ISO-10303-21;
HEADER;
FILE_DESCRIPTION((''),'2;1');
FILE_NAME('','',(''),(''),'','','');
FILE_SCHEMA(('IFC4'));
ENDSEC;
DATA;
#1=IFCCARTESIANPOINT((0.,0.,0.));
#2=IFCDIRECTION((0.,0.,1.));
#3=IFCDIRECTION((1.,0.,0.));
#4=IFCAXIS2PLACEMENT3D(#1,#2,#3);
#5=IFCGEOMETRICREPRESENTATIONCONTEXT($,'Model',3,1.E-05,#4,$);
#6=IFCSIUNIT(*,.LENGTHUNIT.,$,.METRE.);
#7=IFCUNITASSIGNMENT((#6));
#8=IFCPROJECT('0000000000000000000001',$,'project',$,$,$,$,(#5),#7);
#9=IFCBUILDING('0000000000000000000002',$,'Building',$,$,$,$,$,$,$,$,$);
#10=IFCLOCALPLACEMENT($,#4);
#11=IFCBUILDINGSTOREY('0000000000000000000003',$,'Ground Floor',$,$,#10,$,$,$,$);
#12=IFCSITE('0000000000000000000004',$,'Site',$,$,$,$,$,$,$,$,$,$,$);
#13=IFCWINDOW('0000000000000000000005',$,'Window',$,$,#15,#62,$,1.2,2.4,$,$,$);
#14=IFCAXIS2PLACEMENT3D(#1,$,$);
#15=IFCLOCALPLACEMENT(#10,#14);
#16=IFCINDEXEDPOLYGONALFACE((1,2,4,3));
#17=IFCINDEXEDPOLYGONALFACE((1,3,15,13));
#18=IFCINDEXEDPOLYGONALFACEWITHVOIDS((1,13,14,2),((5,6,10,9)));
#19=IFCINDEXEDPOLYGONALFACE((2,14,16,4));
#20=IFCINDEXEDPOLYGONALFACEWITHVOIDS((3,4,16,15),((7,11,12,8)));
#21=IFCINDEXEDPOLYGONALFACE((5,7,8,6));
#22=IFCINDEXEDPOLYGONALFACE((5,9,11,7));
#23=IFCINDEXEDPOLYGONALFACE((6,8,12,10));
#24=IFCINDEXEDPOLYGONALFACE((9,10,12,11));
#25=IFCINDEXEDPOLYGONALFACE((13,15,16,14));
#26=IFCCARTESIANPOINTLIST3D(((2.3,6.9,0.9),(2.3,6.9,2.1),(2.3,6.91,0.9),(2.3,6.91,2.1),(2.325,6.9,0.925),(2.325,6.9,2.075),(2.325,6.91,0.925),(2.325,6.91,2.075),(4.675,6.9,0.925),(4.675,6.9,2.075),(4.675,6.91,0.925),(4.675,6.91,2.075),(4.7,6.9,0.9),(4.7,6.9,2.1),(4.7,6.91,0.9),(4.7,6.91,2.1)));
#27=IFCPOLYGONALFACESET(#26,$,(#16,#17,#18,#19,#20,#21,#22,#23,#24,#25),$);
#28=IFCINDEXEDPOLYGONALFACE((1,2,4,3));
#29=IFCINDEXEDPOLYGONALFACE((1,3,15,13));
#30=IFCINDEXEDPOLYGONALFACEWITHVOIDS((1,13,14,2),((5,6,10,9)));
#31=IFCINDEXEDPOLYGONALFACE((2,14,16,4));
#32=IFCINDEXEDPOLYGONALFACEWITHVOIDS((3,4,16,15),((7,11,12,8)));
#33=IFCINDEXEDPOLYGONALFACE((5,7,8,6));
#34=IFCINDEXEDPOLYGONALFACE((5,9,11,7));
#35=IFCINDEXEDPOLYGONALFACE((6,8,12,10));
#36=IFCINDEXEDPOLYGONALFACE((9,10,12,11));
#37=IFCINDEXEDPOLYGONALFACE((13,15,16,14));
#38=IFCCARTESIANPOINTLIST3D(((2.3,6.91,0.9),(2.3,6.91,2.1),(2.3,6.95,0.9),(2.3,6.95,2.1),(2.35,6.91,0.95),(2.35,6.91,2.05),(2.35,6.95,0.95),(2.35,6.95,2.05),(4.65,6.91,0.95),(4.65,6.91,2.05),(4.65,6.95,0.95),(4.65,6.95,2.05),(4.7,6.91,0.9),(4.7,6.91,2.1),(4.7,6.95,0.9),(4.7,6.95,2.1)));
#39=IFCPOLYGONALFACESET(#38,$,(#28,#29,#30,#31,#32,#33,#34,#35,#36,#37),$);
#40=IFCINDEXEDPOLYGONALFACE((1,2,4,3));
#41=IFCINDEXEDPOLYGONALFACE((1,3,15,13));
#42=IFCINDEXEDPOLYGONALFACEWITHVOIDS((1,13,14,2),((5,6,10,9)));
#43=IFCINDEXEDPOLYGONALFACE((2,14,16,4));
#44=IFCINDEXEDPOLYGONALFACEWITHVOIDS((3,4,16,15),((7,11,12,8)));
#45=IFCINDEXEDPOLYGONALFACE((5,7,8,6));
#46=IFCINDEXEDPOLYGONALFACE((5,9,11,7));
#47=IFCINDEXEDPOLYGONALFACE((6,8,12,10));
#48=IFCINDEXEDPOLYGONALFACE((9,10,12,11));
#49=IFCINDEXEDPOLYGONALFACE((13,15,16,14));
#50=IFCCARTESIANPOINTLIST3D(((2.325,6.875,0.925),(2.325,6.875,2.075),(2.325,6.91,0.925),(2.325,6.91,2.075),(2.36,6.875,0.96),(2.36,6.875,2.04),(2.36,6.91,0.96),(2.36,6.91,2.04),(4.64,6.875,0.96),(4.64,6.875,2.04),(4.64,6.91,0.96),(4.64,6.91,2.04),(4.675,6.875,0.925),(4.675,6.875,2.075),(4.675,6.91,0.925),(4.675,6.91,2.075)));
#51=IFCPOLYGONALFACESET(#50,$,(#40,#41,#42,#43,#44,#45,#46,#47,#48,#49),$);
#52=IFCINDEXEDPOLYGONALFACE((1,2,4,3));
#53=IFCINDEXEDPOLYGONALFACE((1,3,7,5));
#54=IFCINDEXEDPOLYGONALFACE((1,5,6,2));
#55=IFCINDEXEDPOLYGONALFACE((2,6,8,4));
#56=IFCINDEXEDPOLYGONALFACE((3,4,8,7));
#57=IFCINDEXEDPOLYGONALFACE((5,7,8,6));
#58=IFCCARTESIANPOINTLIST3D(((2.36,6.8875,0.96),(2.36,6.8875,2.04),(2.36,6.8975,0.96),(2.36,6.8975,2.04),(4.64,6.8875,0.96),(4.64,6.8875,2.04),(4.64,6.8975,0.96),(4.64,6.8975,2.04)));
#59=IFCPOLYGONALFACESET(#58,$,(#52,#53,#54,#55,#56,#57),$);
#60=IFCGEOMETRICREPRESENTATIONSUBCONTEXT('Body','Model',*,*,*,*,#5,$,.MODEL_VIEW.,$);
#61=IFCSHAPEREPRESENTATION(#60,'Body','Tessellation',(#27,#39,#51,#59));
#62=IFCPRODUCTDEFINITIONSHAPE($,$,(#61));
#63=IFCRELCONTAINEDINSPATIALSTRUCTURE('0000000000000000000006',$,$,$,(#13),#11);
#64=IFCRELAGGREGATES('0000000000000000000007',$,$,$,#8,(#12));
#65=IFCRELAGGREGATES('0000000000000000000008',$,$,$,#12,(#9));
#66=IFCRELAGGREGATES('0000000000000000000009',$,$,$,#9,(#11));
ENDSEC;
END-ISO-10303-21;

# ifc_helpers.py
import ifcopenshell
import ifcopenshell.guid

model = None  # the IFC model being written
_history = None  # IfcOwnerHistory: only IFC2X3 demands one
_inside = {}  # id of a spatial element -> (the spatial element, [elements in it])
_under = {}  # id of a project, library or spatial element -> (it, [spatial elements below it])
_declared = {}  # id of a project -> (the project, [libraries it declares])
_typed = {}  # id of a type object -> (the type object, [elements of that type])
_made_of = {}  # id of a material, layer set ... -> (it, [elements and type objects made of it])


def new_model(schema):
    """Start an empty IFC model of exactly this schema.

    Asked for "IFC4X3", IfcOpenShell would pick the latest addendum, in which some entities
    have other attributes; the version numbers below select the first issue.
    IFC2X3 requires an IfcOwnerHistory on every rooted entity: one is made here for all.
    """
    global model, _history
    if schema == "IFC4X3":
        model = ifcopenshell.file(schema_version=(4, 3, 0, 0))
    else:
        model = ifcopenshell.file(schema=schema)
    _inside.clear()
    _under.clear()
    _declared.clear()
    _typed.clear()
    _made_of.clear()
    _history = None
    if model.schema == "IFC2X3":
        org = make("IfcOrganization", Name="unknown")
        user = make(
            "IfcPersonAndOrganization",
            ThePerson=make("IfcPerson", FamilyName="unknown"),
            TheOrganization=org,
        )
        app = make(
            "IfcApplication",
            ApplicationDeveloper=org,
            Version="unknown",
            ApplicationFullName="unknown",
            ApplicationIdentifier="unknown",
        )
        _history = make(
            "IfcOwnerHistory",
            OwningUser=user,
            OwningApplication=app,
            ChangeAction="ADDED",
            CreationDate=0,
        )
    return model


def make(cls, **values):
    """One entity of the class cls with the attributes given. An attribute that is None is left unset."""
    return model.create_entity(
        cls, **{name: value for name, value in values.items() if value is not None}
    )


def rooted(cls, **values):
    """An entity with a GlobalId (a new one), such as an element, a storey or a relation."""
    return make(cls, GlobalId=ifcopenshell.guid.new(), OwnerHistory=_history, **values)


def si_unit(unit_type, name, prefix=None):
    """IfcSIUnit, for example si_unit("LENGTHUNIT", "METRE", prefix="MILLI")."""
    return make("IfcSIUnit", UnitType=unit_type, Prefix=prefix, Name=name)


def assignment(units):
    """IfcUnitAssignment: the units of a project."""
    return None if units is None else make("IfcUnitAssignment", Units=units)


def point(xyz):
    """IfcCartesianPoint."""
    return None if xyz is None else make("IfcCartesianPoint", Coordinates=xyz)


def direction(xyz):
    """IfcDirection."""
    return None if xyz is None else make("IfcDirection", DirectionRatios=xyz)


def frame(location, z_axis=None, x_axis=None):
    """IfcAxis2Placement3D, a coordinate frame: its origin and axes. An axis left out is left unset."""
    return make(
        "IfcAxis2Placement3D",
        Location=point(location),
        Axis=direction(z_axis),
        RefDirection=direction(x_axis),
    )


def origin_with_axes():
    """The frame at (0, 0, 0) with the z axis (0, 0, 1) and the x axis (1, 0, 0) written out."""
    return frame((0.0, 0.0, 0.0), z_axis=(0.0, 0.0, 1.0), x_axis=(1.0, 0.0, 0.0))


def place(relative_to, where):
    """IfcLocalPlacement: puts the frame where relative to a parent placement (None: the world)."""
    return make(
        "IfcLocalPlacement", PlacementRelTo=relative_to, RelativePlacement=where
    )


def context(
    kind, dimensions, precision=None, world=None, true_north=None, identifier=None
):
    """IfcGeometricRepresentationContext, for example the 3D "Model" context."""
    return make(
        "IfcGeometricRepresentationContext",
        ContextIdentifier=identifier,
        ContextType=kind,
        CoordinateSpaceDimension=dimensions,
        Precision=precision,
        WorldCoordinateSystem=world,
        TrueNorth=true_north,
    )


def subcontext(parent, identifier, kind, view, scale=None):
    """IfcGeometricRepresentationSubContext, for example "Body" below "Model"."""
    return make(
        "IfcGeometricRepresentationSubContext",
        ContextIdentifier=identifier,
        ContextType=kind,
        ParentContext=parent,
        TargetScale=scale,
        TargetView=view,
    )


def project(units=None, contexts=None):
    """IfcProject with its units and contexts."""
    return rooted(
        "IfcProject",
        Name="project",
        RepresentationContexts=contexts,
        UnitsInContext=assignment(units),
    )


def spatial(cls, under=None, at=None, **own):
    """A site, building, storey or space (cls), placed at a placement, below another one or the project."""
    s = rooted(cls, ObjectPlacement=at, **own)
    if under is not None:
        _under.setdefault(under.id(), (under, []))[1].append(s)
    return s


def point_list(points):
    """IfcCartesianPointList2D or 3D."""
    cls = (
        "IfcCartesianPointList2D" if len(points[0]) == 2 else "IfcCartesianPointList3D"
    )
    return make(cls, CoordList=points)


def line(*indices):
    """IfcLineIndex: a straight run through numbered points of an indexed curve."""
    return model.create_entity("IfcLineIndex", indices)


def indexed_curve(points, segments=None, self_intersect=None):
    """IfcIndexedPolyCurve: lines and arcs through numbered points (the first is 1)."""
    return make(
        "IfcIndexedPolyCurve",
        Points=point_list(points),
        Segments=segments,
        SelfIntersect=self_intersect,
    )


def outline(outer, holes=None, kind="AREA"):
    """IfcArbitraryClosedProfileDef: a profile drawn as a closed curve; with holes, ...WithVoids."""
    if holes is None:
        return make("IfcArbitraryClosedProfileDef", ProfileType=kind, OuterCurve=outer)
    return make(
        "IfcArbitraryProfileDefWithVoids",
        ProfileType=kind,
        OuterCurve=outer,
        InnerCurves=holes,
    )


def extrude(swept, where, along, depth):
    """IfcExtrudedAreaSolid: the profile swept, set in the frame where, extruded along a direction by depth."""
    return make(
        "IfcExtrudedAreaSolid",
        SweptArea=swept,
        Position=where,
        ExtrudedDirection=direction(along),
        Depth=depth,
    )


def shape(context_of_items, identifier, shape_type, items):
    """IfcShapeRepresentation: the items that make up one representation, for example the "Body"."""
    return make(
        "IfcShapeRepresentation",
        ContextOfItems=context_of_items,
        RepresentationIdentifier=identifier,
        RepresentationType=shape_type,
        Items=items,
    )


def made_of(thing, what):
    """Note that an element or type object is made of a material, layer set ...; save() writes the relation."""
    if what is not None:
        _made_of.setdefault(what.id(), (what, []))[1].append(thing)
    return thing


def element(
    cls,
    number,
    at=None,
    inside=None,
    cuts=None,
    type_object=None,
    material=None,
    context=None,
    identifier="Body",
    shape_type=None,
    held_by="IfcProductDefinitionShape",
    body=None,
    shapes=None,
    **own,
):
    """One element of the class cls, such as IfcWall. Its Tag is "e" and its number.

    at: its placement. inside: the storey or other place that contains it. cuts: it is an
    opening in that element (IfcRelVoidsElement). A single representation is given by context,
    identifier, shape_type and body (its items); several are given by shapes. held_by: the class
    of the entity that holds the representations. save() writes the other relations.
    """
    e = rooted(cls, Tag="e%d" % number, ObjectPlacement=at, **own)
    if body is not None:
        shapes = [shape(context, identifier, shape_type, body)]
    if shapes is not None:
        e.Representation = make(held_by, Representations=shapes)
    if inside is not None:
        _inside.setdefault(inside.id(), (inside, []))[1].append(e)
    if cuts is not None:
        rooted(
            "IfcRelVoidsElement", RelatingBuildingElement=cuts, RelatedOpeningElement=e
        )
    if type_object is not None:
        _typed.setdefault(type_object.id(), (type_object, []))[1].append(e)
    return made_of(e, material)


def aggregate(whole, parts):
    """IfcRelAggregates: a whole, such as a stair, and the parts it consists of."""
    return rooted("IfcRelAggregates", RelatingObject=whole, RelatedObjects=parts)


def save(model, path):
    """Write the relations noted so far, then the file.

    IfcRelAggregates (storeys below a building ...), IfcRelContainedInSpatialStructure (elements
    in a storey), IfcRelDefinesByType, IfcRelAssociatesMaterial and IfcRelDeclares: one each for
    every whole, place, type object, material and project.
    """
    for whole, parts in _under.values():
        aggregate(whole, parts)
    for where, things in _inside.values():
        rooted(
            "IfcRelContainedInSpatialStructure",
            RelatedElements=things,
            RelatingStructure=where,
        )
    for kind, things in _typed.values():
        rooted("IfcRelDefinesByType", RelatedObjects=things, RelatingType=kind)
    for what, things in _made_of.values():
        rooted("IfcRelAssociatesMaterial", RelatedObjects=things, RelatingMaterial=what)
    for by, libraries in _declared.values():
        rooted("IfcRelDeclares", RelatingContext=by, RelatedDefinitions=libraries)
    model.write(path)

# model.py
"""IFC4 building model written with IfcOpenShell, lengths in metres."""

from ifc_helpers import new_model, si_unit, frame, origin_with_axes, place, context, subcontext, project, spatial, line, indexed_curve, outline, extrude, element, save


model = new_model("IFC4")

# Units and contexts
model_context = context("Model", 3, precision=1e-05, world=origin_with_axes())
body_context = subcontext(model_context, "Body", "Model", "MODEL_VIEW")
ifc_project = project(units=[si_unit("LENGTHUNIT", "METRE")], contexts=[model_context])

# Site, building, storey
site = spatial("IfcSite", under=ifc_project, Name="Site")
building = spatial("IfcBuilding", under=site, Name="Building")
storey_placement = place(None, origin_with_axes())
storey = spatial("IfcBuildingStorey", under=building, at=storey_placement, Name="Ground Floor")

# Window
window_1_placement = place(storey_placement, frame((4.7, 7.0, 0.9), z_axis=(0.0, 0.0, 1.0), x_axis=(-1.0, 0.0, 0.0)))
element("IfcWindow", 1, at=window_1_placement, inside=storey, Name="Window", OverallHeight=1.2, OverallWidth=2.4, context=body_context, shape_type="SweptSolid", body=[
    extrude(outline(indexed_curve([(0.0, 0.0), (2.4, 0.0), (2.4, 1.2), (0.0, 1.2)], segments=[line(1, 2, 3, 4, 1)]), holes=[indexed_curve([(0.025, 0.025), (2.375, 0.025), (2.375, 1.175), (0.025, 1.175)], segments=[line(1, 2, 3, 4, 1)])]), frame((0.0, 0.09, 0.0), z_axis=(0.0, -1.0, 0.0), x_axis=(1.0, 0.0, 0.0)), (0.0, 0.0, -1.0), 0.01),
    extrude(outline(indexed_curve([(0.0, 0.0), (2.4, 0.0), (2.4, 1.2), (0.0, 1.2)], segments=[line(1, 2, 3, 4, 1)]), holes=[indexed_curve([(0.05, 0.05), (2.35, 0.05), (2.35, 1.15), (0.05, 1.15)], segments=[line(1, 2, 3, 4, 1)])]), frame((0.0, 0.05, 0.0), z_axis=(0.0, -1.0, 0.0), x_axis=(1.0, 0.0, 0.0)), (0.0, 0.0, -1.0), 0.04),
    extrude(outline(indexed_curve([(0.0, 0.0), (2.35, 0.0), (2.35, 1.15), (0.0, 1.15)], segments=[line(1, 2, 3, 4, 1)]), holes=[indexed_curve([(0.035, 0.035), (2.315, 0.035), (2.315, 1.115), (0.035, 1.115)], segments=[line(1, 2, 3, 4, 1)])]), frame((0.025, 0.09, 0.025), z_axis=(0.0, -1.0, 0.0), x_axis=(1.0, 0.0, 0.0)), (0.0, 0.0, -1.0), 0.035),
    extrude(outline(indexed_curve([(0.035, 0.035), (2.315, 0.035), (2.315, 1.115), (0.035, 1.115)], segments=[line(1, 2, 3, 4, 1)])), frame((0.025, 0.1025, 0.025), z_axis=(0.0, -1.0, 0.0), x_axis=(1.0, 0.0, 0.0)), (0.0, 0.0, -1.0), 0.01),
])

save(model, "model.ifc")
